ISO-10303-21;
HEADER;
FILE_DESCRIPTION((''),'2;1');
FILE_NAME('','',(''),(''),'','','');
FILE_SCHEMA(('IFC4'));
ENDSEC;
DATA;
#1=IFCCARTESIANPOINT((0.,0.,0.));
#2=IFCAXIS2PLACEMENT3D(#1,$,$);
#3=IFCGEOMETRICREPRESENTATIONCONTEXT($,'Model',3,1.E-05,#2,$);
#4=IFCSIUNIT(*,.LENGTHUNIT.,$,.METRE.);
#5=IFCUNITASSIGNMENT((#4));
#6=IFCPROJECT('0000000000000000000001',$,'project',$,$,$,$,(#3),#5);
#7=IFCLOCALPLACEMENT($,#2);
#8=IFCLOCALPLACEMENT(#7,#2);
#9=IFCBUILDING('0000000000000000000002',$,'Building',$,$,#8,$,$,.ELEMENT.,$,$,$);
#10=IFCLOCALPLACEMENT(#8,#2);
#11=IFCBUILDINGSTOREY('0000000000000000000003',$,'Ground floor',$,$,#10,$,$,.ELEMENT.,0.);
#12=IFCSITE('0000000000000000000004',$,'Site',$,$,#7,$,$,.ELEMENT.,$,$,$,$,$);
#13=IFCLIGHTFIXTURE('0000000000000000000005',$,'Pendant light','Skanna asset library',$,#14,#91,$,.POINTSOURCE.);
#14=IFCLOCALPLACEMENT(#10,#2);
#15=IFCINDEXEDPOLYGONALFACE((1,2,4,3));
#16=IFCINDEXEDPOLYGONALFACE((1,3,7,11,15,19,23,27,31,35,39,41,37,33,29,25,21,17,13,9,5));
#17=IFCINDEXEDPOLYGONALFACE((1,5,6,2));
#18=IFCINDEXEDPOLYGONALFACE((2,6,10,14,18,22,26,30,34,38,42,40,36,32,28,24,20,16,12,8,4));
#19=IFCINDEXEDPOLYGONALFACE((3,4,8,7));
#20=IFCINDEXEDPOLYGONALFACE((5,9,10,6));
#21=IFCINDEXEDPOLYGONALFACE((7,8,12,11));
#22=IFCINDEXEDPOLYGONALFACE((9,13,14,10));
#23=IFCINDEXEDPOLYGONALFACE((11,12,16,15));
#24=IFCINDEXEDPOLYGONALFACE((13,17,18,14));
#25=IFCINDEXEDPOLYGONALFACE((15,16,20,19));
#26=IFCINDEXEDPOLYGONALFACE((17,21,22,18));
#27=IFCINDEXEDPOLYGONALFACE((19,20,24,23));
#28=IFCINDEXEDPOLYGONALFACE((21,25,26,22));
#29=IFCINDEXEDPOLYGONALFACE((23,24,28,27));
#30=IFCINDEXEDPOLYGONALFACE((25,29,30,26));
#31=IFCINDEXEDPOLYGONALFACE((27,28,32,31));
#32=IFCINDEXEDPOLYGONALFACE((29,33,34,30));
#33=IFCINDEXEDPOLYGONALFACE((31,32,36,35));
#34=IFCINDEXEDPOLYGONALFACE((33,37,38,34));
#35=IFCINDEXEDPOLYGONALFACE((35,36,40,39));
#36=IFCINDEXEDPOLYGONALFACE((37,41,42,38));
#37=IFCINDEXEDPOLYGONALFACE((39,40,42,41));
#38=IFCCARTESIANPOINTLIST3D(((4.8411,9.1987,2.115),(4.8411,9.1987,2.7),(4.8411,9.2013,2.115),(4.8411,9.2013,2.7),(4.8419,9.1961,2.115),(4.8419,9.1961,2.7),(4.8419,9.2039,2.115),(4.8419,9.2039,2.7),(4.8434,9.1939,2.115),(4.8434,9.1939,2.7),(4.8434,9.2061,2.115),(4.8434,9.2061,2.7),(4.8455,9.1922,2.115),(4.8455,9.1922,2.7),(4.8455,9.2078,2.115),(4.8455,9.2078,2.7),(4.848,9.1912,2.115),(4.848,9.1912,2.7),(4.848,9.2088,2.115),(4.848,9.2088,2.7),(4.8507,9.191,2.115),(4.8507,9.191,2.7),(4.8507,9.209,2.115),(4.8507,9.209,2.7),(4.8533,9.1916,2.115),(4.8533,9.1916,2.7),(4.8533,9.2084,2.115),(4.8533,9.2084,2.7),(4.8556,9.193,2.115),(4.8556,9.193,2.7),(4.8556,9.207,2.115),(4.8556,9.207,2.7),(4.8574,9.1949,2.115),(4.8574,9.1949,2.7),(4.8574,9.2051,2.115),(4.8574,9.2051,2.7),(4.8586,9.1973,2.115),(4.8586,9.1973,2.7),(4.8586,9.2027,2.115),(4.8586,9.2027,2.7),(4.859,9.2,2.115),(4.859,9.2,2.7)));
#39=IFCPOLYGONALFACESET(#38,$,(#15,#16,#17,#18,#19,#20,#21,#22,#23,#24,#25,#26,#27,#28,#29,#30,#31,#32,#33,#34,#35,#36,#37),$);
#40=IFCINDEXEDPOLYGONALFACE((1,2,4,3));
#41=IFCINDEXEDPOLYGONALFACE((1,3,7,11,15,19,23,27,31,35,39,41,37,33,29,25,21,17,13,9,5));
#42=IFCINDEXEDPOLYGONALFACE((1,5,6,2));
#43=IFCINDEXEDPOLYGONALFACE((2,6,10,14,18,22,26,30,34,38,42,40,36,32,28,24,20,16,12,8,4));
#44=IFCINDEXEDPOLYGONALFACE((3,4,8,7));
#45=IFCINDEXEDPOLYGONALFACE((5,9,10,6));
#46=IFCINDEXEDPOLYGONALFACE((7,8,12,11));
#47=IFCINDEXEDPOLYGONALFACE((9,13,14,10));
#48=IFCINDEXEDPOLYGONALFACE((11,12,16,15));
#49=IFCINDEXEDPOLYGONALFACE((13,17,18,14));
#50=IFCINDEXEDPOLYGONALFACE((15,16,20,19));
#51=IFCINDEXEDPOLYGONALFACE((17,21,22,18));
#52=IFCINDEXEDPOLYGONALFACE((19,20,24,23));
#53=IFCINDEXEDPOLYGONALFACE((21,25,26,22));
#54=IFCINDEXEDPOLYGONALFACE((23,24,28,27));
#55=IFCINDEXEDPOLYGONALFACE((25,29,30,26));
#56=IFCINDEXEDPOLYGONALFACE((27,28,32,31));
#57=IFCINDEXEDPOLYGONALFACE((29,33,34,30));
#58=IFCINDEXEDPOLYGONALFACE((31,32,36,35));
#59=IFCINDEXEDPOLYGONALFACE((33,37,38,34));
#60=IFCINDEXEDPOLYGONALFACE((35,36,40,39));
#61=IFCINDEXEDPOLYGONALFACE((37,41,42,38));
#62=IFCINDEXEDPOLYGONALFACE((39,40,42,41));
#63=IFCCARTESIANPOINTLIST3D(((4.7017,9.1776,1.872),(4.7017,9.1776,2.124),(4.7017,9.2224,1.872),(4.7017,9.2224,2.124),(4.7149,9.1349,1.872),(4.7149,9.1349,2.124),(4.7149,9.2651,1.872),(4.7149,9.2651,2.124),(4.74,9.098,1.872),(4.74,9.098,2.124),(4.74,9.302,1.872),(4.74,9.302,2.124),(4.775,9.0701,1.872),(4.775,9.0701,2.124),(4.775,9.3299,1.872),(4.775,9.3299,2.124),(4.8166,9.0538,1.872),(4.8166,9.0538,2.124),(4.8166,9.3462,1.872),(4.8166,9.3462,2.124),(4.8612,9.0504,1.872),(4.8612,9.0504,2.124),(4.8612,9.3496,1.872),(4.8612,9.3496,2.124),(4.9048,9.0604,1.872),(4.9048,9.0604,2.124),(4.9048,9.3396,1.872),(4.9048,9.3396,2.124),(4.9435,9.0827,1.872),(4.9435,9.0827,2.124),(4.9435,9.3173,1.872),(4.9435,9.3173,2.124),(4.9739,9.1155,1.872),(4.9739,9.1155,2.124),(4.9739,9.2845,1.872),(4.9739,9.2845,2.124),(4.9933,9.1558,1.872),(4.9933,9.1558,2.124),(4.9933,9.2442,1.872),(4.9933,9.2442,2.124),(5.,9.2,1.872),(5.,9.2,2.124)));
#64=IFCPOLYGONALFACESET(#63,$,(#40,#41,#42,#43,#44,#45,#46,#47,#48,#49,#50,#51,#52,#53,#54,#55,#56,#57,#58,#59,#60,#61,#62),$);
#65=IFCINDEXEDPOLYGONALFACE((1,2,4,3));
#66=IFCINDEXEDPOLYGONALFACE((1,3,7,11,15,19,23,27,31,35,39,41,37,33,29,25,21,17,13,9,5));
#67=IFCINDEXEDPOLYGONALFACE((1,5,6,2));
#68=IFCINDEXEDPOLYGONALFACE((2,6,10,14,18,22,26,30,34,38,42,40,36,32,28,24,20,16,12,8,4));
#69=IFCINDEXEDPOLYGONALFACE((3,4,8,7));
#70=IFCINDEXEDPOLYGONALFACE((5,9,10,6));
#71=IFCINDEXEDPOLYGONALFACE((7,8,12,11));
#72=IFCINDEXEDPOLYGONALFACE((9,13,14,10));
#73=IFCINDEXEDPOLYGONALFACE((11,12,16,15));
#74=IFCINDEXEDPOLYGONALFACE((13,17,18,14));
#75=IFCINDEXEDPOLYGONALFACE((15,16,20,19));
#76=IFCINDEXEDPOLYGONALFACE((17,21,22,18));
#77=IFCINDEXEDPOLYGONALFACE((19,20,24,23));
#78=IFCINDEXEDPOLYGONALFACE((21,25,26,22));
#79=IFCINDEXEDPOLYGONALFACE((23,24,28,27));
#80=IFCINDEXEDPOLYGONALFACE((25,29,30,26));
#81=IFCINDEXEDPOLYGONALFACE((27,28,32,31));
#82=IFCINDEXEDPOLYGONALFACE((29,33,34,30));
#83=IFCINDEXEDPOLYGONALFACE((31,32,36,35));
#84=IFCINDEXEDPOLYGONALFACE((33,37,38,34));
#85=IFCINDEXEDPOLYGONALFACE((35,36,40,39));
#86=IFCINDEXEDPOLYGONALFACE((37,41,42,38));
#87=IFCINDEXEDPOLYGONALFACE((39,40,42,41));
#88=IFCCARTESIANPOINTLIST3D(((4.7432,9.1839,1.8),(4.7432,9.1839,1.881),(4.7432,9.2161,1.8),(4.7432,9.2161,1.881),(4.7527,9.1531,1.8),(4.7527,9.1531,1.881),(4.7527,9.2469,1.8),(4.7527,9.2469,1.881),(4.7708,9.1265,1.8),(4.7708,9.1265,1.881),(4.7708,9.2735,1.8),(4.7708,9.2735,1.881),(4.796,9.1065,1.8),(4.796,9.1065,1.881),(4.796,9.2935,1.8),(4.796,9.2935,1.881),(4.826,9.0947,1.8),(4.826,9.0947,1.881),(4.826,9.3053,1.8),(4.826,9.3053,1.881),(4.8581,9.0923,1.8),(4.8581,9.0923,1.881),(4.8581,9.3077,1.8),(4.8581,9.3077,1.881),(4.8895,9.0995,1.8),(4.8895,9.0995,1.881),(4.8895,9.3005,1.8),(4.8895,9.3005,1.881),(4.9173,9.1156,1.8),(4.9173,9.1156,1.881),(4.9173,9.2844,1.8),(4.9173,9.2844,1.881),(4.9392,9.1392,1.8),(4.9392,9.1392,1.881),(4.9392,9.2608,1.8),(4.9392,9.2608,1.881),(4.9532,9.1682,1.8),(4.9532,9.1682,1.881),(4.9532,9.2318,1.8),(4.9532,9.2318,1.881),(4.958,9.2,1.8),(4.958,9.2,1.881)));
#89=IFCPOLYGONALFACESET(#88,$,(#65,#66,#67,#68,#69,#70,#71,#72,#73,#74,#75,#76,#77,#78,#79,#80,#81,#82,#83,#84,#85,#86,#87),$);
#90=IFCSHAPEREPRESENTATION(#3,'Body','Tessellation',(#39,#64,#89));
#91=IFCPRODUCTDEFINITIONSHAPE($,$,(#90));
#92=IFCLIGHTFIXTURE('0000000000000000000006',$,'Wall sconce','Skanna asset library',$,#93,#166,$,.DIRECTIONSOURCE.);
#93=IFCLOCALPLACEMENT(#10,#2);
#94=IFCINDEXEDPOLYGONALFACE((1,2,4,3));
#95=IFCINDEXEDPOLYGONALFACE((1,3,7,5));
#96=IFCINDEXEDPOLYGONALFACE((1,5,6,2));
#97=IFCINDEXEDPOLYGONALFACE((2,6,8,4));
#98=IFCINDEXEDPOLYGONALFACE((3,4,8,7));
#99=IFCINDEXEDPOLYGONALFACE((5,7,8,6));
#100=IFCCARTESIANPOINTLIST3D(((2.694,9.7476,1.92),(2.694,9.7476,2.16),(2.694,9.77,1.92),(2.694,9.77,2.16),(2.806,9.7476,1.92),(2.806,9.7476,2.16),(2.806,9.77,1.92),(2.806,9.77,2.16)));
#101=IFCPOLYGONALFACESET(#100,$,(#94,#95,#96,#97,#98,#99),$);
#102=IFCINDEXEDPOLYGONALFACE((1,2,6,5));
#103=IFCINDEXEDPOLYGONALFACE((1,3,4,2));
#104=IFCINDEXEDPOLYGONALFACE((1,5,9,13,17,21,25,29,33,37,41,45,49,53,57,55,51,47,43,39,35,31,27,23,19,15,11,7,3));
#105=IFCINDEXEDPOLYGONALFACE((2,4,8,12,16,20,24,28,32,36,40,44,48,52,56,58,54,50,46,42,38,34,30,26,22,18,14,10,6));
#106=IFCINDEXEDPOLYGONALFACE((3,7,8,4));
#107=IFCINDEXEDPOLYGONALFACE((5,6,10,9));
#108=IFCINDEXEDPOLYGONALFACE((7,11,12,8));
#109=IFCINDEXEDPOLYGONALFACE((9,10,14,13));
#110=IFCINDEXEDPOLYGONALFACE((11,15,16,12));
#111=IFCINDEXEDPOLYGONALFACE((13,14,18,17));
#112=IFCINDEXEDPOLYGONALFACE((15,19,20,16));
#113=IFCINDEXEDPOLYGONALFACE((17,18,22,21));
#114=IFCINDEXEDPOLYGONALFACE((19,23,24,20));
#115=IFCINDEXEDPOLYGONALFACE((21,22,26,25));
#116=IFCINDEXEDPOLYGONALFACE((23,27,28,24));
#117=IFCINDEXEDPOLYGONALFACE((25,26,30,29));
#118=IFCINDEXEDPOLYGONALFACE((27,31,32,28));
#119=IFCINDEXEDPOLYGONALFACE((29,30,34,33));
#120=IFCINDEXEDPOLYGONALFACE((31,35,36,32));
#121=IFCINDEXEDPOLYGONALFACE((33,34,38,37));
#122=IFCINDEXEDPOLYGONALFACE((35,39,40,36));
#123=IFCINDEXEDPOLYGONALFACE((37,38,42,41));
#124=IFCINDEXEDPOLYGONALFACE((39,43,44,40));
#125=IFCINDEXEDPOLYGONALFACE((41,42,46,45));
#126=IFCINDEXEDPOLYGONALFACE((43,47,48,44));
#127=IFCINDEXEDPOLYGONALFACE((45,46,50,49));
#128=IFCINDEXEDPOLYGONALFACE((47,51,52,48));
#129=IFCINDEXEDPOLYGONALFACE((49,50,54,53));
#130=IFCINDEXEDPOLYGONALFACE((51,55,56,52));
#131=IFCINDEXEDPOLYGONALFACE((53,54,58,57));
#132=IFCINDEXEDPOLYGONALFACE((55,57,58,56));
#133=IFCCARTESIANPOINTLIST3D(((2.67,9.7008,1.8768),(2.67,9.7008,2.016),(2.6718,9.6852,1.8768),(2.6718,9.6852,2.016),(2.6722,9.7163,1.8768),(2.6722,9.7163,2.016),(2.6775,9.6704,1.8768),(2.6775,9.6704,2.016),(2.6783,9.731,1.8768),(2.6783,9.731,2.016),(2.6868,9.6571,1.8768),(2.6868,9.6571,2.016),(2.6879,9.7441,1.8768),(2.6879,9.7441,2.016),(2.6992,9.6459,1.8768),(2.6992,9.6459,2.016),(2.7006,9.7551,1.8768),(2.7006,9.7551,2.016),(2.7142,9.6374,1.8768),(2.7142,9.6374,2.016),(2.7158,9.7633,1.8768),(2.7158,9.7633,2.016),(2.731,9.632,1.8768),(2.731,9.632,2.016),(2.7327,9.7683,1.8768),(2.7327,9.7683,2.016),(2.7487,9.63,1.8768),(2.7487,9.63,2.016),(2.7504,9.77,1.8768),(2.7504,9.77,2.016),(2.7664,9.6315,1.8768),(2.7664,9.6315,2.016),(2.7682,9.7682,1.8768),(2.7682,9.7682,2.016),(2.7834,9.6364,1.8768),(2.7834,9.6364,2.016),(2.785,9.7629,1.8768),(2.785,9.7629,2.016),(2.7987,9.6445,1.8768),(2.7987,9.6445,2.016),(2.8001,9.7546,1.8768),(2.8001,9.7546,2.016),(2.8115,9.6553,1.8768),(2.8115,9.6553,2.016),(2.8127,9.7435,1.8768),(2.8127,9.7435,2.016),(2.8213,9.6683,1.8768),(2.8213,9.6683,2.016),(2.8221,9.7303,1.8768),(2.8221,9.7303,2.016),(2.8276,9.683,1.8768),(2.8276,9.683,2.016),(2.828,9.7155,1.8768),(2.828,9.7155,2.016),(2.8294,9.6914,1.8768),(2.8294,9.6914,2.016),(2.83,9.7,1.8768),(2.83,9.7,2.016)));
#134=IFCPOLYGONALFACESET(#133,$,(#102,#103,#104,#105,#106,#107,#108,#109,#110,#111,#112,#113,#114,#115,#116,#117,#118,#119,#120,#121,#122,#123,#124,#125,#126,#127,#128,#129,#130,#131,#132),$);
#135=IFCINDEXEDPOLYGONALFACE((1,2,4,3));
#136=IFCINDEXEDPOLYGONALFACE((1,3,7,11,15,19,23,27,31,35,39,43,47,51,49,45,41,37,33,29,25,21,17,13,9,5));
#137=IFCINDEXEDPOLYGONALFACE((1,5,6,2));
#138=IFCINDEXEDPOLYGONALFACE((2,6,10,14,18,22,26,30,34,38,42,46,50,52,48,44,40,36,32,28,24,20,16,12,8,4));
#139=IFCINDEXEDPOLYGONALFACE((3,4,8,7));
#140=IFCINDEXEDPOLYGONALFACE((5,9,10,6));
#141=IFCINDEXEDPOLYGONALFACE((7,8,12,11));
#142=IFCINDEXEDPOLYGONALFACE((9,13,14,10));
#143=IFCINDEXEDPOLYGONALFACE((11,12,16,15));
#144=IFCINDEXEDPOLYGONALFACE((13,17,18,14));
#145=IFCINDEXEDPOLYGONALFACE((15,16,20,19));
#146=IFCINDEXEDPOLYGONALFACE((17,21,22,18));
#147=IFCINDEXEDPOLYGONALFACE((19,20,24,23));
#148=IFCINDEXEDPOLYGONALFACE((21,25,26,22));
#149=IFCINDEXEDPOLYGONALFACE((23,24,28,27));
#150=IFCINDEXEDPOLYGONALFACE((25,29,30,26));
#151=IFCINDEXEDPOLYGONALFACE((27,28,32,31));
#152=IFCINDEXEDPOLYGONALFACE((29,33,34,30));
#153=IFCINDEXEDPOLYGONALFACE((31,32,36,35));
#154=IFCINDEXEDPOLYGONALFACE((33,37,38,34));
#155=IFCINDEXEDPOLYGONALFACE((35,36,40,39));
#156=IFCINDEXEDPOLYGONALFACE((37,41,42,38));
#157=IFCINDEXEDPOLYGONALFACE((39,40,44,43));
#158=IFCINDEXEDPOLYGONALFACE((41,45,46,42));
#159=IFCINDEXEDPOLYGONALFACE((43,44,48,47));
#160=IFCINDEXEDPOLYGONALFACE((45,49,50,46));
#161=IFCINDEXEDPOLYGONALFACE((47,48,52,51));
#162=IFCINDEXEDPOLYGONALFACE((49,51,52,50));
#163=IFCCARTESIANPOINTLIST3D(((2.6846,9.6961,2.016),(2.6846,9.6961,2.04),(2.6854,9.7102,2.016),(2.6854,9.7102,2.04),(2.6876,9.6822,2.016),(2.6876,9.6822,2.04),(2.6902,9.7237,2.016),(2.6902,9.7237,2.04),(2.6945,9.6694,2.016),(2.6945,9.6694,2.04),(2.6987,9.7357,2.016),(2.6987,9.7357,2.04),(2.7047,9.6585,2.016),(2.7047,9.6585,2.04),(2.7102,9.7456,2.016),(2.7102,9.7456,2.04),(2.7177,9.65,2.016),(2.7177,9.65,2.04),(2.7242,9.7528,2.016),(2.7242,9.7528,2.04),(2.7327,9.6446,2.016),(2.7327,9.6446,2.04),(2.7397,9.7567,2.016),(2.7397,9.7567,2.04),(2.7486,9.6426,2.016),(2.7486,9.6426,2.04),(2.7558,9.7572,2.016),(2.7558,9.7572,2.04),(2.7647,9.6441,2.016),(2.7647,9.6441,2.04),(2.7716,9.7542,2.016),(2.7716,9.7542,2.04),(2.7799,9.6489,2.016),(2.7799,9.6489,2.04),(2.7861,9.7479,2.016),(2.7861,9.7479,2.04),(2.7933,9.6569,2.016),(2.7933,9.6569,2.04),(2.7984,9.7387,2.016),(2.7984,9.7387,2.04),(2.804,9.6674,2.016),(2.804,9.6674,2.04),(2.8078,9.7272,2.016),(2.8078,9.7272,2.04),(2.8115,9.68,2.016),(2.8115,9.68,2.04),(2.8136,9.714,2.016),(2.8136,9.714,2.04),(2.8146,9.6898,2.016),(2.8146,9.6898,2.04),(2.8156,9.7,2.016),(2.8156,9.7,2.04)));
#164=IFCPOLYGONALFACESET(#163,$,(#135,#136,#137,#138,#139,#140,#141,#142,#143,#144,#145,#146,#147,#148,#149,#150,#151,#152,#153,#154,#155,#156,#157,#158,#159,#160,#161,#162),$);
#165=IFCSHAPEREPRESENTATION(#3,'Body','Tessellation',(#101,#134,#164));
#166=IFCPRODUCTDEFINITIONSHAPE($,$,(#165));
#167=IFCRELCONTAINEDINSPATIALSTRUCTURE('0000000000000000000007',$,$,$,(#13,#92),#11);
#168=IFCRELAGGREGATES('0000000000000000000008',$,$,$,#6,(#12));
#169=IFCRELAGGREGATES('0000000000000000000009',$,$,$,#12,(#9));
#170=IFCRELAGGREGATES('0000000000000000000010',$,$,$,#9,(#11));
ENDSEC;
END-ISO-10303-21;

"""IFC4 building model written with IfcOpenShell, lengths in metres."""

from ifc_helpers import new_model, si_unit, frame, frame_2d, origin, origin_2d, place, context, project, spatial, rectangle, circle, ellipse, extrude, element, save


model = new_model("IFC4")

# Units and contexts
model_context = context("Model", 3, precision=1e-05, world=origin())
ifc_project = project(units=[si_unit("LENGTHUNIT", "METRE")], contexts=[model_context])

# Site, building, storey
site_placement = place(None, origin())
site = spatial("IfcSite", under=ifc_project, at=site_placement, Name="Site", CompositionType="ELEMENT")
building_placement = place(site_placement, origin())
building = spatial("IfcBuilding", under=site, at=building_placement, Name="Building", CompositionType="ELEMENT")
storey_placement = place(building_placement, origin())
storey = spatial("IfcBuildingStorey", under=building, at=storey_placement, Name="Ground floor", CompositionType="ELEMENT", Elevation=0.0)

# Light fixtures
light_fixture_1_placement = place(storey_placement, frame((4.85, 9.2, 1.8), z_axis=(0.0, 0.0, 1.0), x_axis=(1.0, 0.0, 0.0)))
element("IfcLightFixture", 1, at=light_fixture_1_placement, inside=storey, Name="Pendant light", Description="Skanna asset library", PredefinedType="POINTSOURCE", context=model_context, shape_type="SweptSolid", body=[
    extrude(circle(Radius=0.009, at=origin_2d()), frame((0.0, 0.0, 0.315)), (0.0, 0.0, 1.0), 0.585),
    extrude(circle(Radius=0.15, at=origin_2d()), frame((0.0, 0.0, 0.072)), (0.0, 0.0, 1.0), 0.252),
    extrude(circle(Radius=0.108, at=origin_2d()), origin(), (0.0, 0.0, 1.0), 0.081),
])
light_fixture_2_placement = place(storey_placement, frame((2.75, 9.7, 1.8), z_axis=(0.0, 0.0, 1.0), x_axis=(1.0, 0.0, 0.0)))
element("IfcLightFixture", 2, at=light_fixture_2_placement, inside=storey, Name="Wall sconce", Description="Skanna asset library", PredefinedType="DIRECTIONSOURCE", context=model_context, shape_type="SweptSolid", body=[
    extrude(rectangle(XDim=0.112, YDim=0.0224, at=frame_2d((0.0, 0.0588))), frame((0.0, 0.0, 0.12)), (0.0, 0.0, 1.0), 0.24),
    extrude(ellipse(SemiAxis1=0.08, SemiAxis2=0.07, at=origin_2d()), frame((0.0, 0.0, 0.0768)), (0.0, 0.0, 1.0), 0.1392),
    extrude(ellipse(SemiAxis1=0.0656, SemiAxis2=0.0574, at=origin_2d()), frame((0.0, 0.0, 0.216)), (0.0, 0.0, 1.0), 0.024),
])

save(model, "model.ifc")
